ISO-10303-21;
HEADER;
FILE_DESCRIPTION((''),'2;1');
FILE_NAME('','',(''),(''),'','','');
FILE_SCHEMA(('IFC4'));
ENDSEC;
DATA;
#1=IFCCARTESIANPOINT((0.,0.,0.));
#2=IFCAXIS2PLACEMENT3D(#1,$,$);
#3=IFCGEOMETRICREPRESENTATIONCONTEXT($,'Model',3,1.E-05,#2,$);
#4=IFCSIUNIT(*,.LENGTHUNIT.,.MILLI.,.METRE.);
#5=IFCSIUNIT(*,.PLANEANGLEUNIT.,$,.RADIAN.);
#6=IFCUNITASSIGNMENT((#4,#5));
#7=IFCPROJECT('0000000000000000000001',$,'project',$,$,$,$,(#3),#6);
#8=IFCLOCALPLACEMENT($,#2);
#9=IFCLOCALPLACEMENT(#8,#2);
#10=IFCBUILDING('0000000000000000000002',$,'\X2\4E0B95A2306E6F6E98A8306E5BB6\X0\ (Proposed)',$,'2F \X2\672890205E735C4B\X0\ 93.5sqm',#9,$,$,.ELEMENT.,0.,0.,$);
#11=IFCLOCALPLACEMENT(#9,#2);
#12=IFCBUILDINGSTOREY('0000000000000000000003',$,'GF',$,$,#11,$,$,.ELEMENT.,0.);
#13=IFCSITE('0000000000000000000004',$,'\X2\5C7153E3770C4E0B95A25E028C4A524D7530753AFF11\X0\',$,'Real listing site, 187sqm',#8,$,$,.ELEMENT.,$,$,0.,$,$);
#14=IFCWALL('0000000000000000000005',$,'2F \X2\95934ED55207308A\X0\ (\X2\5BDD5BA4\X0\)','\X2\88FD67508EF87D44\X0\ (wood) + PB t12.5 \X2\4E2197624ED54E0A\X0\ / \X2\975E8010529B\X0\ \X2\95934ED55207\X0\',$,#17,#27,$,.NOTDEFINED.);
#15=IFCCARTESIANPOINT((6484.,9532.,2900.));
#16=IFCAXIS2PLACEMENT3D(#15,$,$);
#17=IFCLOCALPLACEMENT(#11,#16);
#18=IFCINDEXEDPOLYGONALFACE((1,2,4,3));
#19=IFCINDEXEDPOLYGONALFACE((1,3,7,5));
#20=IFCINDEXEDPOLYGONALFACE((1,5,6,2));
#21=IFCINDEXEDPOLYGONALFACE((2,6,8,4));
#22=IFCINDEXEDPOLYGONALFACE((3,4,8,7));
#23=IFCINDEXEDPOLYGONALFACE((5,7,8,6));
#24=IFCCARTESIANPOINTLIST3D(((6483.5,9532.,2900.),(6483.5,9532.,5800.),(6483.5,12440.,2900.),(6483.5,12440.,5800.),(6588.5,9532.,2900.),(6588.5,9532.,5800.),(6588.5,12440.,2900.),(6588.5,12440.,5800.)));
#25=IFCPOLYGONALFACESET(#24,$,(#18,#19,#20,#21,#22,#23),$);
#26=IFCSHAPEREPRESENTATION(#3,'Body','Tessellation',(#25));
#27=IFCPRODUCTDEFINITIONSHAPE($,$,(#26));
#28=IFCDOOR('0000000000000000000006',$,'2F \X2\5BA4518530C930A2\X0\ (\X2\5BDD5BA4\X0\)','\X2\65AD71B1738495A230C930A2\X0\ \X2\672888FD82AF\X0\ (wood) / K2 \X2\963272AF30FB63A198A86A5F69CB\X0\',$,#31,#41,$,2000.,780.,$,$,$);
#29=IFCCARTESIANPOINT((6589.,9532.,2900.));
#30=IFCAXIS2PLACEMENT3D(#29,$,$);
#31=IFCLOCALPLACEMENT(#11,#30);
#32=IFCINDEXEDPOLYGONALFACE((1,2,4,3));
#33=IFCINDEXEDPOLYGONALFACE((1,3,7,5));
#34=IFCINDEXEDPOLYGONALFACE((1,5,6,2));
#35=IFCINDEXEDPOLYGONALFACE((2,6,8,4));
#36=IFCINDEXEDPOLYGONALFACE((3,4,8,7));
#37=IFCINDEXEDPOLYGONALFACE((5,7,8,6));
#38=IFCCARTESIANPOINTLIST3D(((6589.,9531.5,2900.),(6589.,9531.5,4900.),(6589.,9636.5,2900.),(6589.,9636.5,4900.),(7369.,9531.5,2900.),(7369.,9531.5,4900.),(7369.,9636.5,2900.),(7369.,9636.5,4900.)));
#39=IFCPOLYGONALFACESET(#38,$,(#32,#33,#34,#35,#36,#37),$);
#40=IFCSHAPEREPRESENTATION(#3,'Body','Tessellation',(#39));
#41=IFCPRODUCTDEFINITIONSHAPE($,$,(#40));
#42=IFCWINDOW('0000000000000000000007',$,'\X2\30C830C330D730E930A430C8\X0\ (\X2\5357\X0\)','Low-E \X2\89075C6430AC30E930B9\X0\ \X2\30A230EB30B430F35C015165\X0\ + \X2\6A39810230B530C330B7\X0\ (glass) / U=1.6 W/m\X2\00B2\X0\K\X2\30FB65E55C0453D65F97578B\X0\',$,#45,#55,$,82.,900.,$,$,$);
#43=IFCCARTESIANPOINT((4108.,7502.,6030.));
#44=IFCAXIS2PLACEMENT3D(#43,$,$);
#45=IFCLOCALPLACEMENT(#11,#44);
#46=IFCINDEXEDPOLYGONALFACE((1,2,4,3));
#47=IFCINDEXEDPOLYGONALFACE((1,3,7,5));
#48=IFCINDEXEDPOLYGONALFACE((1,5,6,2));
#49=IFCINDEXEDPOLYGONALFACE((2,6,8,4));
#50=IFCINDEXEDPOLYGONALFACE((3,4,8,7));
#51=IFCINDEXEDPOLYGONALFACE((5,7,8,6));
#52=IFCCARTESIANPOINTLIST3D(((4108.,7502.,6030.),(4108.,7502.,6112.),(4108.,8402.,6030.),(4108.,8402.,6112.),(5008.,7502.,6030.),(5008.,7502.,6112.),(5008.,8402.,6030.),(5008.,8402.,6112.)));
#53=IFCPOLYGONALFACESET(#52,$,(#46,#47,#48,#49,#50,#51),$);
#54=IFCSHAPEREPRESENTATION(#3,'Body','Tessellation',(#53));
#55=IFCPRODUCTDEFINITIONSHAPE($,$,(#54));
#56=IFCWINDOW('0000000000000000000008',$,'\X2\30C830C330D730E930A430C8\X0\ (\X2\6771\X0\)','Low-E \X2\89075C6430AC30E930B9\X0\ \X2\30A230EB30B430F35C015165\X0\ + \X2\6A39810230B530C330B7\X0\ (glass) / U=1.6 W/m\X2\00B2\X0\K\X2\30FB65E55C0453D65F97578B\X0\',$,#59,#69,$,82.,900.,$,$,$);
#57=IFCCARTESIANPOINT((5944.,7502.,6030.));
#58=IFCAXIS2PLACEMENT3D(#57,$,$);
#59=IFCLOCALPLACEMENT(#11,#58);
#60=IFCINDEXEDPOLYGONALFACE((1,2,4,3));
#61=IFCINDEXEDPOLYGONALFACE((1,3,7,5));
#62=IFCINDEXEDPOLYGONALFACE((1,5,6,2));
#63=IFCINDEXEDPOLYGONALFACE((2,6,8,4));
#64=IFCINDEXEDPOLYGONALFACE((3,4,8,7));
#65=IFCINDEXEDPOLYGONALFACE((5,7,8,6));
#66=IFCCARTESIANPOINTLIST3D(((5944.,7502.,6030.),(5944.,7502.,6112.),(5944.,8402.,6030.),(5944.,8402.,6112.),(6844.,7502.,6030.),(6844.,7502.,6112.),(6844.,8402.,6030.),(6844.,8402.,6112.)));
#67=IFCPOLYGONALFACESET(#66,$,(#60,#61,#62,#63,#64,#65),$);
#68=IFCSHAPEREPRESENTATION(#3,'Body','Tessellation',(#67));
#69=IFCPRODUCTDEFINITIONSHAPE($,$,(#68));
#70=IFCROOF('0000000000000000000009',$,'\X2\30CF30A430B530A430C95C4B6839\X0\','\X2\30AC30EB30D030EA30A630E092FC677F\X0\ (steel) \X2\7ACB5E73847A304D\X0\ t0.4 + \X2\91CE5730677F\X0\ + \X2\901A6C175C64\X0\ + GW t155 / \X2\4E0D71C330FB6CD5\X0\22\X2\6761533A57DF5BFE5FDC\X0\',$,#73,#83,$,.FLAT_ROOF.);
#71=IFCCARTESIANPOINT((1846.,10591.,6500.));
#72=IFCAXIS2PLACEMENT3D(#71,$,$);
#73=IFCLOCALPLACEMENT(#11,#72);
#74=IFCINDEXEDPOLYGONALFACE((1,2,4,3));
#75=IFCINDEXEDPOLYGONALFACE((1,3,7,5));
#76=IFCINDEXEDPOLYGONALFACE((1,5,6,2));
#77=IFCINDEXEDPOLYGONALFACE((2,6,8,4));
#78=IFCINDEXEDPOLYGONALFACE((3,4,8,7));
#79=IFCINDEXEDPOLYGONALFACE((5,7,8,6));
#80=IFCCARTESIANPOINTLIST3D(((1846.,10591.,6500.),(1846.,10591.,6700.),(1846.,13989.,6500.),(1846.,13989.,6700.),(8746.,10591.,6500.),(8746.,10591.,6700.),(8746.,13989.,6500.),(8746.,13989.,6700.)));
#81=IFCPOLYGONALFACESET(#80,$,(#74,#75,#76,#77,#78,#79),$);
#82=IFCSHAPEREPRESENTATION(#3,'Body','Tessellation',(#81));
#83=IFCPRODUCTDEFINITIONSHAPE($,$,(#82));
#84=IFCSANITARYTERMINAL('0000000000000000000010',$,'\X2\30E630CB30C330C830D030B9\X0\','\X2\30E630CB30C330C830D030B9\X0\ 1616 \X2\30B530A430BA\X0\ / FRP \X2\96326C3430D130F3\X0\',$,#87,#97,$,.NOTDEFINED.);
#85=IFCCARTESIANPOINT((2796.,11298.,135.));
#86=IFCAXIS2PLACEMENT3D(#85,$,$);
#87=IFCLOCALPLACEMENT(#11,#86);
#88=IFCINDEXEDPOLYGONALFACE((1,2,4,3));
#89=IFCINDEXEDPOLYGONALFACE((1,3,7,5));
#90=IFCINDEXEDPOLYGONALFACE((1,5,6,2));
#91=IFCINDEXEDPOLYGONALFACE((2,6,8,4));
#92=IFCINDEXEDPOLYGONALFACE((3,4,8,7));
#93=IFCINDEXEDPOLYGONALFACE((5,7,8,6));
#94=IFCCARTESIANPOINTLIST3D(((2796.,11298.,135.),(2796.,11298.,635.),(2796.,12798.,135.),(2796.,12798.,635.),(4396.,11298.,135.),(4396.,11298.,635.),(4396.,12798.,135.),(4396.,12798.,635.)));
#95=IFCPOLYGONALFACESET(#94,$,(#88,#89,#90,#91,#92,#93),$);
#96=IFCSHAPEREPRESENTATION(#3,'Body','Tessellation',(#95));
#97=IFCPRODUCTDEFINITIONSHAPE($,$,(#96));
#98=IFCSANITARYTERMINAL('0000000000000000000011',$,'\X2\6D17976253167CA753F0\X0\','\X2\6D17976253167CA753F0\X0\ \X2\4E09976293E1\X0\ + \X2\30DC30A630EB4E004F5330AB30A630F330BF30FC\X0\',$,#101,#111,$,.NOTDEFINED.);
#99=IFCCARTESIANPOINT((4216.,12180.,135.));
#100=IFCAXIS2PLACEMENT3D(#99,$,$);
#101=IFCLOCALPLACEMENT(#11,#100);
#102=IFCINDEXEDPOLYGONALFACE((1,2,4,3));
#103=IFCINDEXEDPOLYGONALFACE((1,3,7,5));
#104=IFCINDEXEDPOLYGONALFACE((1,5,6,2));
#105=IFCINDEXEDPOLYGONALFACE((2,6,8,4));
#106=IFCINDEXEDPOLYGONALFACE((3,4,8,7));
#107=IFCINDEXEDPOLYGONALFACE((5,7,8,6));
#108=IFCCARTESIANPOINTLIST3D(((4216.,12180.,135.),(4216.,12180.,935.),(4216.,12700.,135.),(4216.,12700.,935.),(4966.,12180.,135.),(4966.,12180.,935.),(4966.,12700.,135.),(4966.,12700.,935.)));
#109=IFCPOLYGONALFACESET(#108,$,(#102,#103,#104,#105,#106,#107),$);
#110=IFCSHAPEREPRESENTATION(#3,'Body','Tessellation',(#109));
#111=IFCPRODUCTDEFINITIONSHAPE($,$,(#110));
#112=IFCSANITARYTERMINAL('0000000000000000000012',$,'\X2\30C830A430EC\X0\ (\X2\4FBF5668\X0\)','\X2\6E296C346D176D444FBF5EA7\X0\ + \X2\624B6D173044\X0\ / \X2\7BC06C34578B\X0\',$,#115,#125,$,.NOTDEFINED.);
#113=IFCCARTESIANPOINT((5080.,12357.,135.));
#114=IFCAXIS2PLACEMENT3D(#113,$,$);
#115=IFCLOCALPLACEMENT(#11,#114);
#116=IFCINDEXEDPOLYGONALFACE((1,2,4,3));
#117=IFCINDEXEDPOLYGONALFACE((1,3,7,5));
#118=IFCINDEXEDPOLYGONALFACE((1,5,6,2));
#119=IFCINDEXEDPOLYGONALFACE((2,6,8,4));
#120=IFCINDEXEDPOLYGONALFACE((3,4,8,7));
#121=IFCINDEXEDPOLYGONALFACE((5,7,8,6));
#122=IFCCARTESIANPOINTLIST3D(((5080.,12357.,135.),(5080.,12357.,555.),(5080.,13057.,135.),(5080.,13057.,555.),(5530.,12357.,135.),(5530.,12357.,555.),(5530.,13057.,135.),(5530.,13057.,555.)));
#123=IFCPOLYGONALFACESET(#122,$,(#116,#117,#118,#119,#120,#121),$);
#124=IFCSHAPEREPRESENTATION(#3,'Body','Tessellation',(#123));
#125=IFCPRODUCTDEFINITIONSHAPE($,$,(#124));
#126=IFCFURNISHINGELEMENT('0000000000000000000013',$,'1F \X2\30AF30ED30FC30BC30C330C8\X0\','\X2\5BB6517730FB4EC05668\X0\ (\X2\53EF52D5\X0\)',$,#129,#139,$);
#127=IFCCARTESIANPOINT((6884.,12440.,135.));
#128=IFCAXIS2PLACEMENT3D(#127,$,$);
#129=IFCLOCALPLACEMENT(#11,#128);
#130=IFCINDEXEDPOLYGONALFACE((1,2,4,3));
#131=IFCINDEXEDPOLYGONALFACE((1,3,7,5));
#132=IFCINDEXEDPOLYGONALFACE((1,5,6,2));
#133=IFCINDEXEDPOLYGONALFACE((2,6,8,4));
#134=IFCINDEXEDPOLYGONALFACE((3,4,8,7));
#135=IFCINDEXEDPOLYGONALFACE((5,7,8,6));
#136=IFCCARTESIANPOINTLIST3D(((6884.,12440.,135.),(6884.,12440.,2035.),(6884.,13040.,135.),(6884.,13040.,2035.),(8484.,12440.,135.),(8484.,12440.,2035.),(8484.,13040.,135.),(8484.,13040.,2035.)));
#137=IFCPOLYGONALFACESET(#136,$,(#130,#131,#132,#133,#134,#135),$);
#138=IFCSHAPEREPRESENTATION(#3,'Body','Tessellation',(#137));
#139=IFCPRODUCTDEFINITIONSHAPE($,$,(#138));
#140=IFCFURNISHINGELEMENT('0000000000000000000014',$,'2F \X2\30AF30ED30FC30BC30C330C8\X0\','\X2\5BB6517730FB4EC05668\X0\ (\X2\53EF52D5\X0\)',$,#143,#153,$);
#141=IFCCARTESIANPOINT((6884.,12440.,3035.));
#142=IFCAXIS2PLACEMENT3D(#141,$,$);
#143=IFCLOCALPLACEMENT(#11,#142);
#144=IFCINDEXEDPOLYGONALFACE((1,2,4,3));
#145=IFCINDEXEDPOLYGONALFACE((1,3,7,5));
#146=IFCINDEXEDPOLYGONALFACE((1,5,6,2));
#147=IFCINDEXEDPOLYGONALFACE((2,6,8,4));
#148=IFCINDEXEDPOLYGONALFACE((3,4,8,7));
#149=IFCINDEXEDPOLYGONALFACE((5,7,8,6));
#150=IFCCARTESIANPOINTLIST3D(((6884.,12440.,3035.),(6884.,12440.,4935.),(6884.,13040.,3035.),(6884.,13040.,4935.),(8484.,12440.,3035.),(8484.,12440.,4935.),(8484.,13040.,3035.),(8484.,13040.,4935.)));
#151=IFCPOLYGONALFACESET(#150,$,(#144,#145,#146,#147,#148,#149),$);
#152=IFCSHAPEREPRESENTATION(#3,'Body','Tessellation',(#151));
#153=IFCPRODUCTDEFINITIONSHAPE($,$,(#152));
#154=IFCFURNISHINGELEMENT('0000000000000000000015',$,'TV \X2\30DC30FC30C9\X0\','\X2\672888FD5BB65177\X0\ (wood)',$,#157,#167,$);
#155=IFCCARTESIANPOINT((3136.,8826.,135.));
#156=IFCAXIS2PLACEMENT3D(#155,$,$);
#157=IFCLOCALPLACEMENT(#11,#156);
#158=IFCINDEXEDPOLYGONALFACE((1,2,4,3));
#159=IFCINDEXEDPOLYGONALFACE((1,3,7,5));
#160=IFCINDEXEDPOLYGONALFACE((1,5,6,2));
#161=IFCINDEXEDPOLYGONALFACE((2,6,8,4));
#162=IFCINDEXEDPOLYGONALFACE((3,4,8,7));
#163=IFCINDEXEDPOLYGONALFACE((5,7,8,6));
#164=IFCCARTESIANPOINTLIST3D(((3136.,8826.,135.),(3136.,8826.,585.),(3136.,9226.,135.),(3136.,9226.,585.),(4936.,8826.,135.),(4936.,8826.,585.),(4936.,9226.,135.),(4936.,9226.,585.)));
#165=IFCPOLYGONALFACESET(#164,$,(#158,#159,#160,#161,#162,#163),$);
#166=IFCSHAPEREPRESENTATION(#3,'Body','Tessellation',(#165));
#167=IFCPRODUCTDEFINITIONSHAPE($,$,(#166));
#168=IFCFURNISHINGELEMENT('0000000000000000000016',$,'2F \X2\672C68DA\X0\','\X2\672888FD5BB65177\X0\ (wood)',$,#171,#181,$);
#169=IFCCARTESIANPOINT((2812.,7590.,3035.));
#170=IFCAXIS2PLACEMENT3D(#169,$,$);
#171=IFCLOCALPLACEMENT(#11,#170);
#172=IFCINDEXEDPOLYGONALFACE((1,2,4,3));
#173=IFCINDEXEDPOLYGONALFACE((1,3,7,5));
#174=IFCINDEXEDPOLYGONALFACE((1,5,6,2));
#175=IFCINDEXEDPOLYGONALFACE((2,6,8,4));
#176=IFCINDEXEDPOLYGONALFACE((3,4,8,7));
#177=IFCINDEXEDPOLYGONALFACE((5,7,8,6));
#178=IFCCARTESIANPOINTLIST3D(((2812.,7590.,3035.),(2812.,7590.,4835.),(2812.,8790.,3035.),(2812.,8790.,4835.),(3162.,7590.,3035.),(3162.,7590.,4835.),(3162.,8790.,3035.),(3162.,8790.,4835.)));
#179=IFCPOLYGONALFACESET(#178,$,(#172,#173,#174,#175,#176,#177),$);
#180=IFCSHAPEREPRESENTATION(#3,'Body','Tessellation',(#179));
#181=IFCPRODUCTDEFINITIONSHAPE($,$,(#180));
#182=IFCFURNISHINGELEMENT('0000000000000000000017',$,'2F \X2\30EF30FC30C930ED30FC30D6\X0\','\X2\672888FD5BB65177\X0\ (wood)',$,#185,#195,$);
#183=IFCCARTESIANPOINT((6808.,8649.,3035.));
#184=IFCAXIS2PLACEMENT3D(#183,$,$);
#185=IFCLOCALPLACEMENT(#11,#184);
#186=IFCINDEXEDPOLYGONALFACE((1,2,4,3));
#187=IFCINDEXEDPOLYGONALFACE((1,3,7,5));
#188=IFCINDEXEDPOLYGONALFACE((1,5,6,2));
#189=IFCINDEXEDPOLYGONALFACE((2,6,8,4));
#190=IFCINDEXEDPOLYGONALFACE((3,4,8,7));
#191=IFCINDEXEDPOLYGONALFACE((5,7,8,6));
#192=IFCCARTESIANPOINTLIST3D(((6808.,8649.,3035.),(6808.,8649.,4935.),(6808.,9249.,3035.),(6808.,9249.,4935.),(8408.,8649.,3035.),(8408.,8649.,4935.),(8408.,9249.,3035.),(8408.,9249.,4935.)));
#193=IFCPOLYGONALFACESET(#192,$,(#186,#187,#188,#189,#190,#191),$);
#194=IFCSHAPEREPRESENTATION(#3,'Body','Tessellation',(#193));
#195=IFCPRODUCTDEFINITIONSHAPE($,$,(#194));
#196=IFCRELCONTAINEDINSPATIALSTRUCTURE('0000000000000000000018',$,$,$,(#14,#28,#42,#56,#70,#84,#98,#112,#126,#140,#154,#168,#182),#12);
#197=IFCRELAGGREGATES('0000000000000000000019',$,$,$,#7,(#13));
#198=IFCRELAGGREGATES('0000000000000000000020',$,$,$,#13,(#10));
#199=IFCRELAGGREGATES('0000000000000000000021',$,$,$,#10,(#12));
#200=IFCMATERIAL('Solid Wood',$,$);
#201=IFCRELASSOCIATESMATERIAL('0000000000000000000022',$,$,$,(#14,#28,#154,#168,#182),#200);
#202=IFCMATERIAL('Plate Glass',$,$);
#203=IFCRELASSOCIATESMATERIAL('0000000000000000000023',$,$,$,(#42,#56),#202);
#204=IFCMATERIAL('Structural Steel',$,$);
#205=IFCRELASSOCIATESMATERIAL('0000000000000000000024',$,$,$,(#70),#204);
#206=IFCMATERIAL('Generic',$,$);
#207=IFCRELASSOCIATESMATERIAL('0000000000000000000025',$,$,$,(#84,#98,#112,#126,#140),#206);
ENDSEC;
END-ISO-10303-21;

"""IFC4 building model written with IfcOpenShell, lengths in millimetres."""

from ifc_helpers import new_model, si_unit, frame, frame_2d, origin, place, context, project, spatial, rectangle, extrude, material, element, save


model = new_model("IFC4")

# Units and contexts
model_context = context("Model", 3, precision=1e-05, world=origin())
ifc_project = project(units=[si_unit("LENGTHUNIT", "METRE", prefix="MILLI"), si_unit("PLANEANGLEUNIT", "RADIAN")], contexts=[model_context])

# Site, building, storey
site_placement = place(None, origin())
site = spatial("IfcSite", under=ifc_project, at=site_placement, Name="山口県下関市豊前田町１", ObjectType="Real listing site, 187sqm", CompositionType="ELEMENT", RefElevation=0.0)
building_placement = place(site_placement, origin())
building = spatial("IfcBuilding", under=site, at=building_placement, Name="下関の潮風の家 (Proposed)", ObjectType="2F 木造平屋 93.5sqm", CompositionType="ELEMENT", ElevationOfRefHeight=0.0, ElevationOfTerrain=0.0)
storey_placement = place(building_placement, origin())
storey = spatial("IfcBuildingStorey", under=building, at=storey_placement, Name="GF", CompositionType="ELEMENT", Elevation=0.0)

# Shared definitions
ifc_material_1 = material(Name="Solid Wood")
ifc_material_2 = material(Name="Plate Glass")

# Wall
wall_1_placement = place(storey_placement, frame((6484.0, 9532.0, 2900.0)))
element("IfcWall", 1, at=wall_1_placement, inside=storey, material=ifc_material_1, Name="2F 間仕切り (寝室)", Description="製材軸組 (wood) + PB t12.5 両面仕上 / 非耐力 間仕切", PredefinedType="NOTDEFINED", context=model_context, shape_type="SweptSolid", body=[
    extrude(rectangle(XDim=105.0, YDim=2908.0, at=frame_2d((52.0, 1454.0))), frame((6484.0, 9532.0, 2900.0)), (0.0, 0.0, 1.0), 2900.0),
])

# Door
door_1_placement = place(storey_placement, frame((6589.0, 9532.0, 2900.0)))
element("IfcDoor", 2, at=door_1_placement, inside=storey, material=ifc_material_1, Name="2F 室内ドア (寝室)", Description="断熱玄関ドア 木製芯 (wood) / K2 防犯・採風機構", OverallHeight=2000.0, OverallWidth=780.0, context=model_context, shape_type="SweptSolid", body=[
    extrude(rectangle(XDim=780.0, YDim=105.0, at=frame_2d((390.0, 52.0))), frame((6589.0, 9532.0, 2900.0)), (0.0, 0.0, 1.0), 2000.0),
])

# Windows
window_1_placement = place(storey_placement, frame((4108.0, 7502.0, 6030.0)))
element("IfcWindow", 3, at=window_1_placement, inside=storey, material=ifc_material_2, Name="トップライト (南)", Description="Low-E 複層ガラス アルゴン封入 + 樹脂サッシ (glass) / U=1.6 W/m²K・日射取得型", OverallHeight=82.0, OverallWidth=900.0, context=model_context, shape_type="SweptSolid", body=[
    extrude(rectangle(XDim=900.0, YDim=900.0, at=frame_2d((450.0, 450.0))), frame((4108.0, 7502.0, 6030.0)), (0.0, 0.0, 1.0), 82.0),
])
window_2_placement = place(storey_placement, frame((5944.0, 7502.0, 6030.0)))
element("IfcWindow", 4, at=window_2_placement, inside=storey, material=ifc_material_2, Name="トップライト (東)", Description="Low-E 複層ガラス アルゴン封入 + 樹脂サッシ (glass) / U=1.6 W/m²K・日射取得型", OverallHeight=82.0, OverallWidth=900.0, context=model_context, shape_type="SweptSolid", body=[
    extrude(rectangle(XDim=900.0, YDim=900.0, at=frame_2d((450.0, 450.0))), frame((5944.0, 7502.0, 6030.0)), (0.0, 0.0, 1.0), 82.0),
])

# Roof
ifc_material_3 = material(Name="Structural Steel")
roof_placement = place(storey_placement, frame((1846.0, 10591.0, 6500.0)))
element("IfcRoof", 5, at=roof_placement, inside=storey, material=ifc_material_3, Name="ハイサイド屋根", Description="ガルバリウム鋼板 (steel) 立平葺き t0.4 + 野地板 + 通気層 + GW t155 / 不燃・法22条区域対応", PredefinedType="FLAT_ROOF", context=model_context, shape_type="SweptSolid", body=[
    extrude(rectangle(XDim=6900.0, YDim=3398.0, at=frame_2d((3450.0, 1699.0))), frame((1846.0, 10591.0, 6500.0)), (0.0, 0.0, 1.0), 200.0),
])

# Sanitary terminals
ifc_material_4 = material(Name="Generic")
sanitary_terminal_1_placement = place(storey_placement, frame((2796.0, 11298.0, 135.0)))
element("IfcSanitaryTerminal", 6, at=sanitary_terminal_1_placement, inside=storey, material=ifc_material_4, Name="ユニットバス", Description="ユニットバス 1616 サイズ / FRP 防水パン", PredefinedType="NOTDEFINED", context=model_context, shape_type="SweptSolid", body=[
    extrude(rectangle(XDim=1600.0, YDim=1500.0, at=frame_2d((800.0, 750.0))), frame((2796.0, 11298.0, 135.0)), (0.0, 0.0, 1.0), 500.0),
])
sanitary_terminal_2_placement = place(storey_placement, frame((4216.0, 12180.0, 135.0)))
element("IfcSanitaryTerminal", 7, at=sanitary_terminal_2_placement, inside=storey, material=ifc_material_4, Name="洗面化粧台", Description="洗面化粧台 三面鏡 + ボウル一体カウンター", PredefinedType="NOTDEFINED", context=model_context, shape_type="SweptSolid", body=[
    extrude(rectangle(XDim=750.0, YDim=520.0, at=frame_2d((375.0, 260.0))), frame((4216.0, 12180.0, 135.0)), (0.0, 0.0, 1.0), 800.0),
])
sanitary_terminal_3_placement = place(storey_placement, frame((5080.0, 12357.0, 135.0)))
element("IfcSanitaryTerminal", 8, at=sanitary_terminal_3_placement, inside=storey, material=ifc_material_4, Name="トイレ (便器)", Description="温水洗浄便座 + 手洗い / 節水型", PredefinedType="NOTDEFINED", context=model_context, shape_type="SweptSolid", body=[
    extrude(rectangle(XDim=450.0, YDim=700.0, at=frame_2d((225.0, 350.0))), frame((5080.0, 12357.0, 135.0)), (0.0, 0.0, 1.0), 420.0),
])

# Furnishing elements
furnishing_1_placement = place(storey_placement, frame((6884.0, 12440.0, 135.0)))
element("IfcFurnishingElement", 9, at=furnishing_1_placement, inside=storey, material=ifc_material_4, Name="1F クローゼット", Description="家具・什器 (可動)", context=model_context, shape_type="SweptSolid", body=[
    extrude(rectangle(XDim=1600.0, YDim=600.0, at=frame_2d((800.0, 300.0))), frame((6884.0, 12440.0, 135.0)), (0.0, 0.0, 1.0), 1900.0),
])
furnishing_2_placement = place(storey_placement, frame((6884.0, 12440.0, 3035.0)))
element("IfcFurnishingElement", 10, at=furnishing_2_placement, inside=storey, material=ifc_material_4, Name="2F クローゼット", Description="家具・什器 (可動)", context=model_context, shape_type="SweptSolid", body=[
    extrude(rectangle(XDim=1600.0, YDim=600.0, at=frame_2d((800.0, 300.0))), frame((6884.0, 12440.0, 3035.0)), (0.0, 0.0, 1.0), 1900.0),
])
furnishing_3_placement = place(storey_placement, frame((3136.0, 8826.0, 135.0)))
element("IfcFurnishingElement", 11, at=furnishing_3_placement, inside=storey, material=ifc_material_1, Name="TV ボード", Description="木製家具 (wood)", context=model_context, shape_type="SweptSolid", body=[
    extrude(rectangle(XDim=1800.0, YDim=400.0, at=frame_2d((900.0, 200.0))), frame((3136.0, 8826.0, 135.0)), (0.0, 0.0, 1.0), 450.0),
])
furnishing_4_placement = place(storey_placement, frame((2812.0, 7590.0, 3035.0)))
element("IfcFurnishingElement", 12, at=furnishing_4_placement, inside=storey, material=ifc_material_1, Name="2F 本棚", Description="木製家具 (wood)", context=model_context, shape_type="SweptSolid", body=[
    extrude(rectangle(XDim=350.0, YDim=1200.0, at=frame_2d((175.0, 600.0))), frame((2812.0, 7590.0, 3035.0)), (0.0, 0.0, 1.0), 1800.0),
])
furnishing_5_placement = place(storey_placement, frame((6808.0, 8649.0, 3035.0)))
element("IfcFurnishingElement", 13, at=furnishing_5_placement, inside=storey, material=ifc_material_1, Name="2F ワードローブ", Description="木製家具 (wood)", context=model_context, shape_type="SweptSolid", body=[
    extrude(rectangle(XDim=1600.0, YDim=600.0, at=frame_2d((800.0, 300.0))), frame((6808.0, 8649.0, 3035.0)), (0.0, 0.0, 1.0), 1900.0),
])

save(model, "model.ifc")
